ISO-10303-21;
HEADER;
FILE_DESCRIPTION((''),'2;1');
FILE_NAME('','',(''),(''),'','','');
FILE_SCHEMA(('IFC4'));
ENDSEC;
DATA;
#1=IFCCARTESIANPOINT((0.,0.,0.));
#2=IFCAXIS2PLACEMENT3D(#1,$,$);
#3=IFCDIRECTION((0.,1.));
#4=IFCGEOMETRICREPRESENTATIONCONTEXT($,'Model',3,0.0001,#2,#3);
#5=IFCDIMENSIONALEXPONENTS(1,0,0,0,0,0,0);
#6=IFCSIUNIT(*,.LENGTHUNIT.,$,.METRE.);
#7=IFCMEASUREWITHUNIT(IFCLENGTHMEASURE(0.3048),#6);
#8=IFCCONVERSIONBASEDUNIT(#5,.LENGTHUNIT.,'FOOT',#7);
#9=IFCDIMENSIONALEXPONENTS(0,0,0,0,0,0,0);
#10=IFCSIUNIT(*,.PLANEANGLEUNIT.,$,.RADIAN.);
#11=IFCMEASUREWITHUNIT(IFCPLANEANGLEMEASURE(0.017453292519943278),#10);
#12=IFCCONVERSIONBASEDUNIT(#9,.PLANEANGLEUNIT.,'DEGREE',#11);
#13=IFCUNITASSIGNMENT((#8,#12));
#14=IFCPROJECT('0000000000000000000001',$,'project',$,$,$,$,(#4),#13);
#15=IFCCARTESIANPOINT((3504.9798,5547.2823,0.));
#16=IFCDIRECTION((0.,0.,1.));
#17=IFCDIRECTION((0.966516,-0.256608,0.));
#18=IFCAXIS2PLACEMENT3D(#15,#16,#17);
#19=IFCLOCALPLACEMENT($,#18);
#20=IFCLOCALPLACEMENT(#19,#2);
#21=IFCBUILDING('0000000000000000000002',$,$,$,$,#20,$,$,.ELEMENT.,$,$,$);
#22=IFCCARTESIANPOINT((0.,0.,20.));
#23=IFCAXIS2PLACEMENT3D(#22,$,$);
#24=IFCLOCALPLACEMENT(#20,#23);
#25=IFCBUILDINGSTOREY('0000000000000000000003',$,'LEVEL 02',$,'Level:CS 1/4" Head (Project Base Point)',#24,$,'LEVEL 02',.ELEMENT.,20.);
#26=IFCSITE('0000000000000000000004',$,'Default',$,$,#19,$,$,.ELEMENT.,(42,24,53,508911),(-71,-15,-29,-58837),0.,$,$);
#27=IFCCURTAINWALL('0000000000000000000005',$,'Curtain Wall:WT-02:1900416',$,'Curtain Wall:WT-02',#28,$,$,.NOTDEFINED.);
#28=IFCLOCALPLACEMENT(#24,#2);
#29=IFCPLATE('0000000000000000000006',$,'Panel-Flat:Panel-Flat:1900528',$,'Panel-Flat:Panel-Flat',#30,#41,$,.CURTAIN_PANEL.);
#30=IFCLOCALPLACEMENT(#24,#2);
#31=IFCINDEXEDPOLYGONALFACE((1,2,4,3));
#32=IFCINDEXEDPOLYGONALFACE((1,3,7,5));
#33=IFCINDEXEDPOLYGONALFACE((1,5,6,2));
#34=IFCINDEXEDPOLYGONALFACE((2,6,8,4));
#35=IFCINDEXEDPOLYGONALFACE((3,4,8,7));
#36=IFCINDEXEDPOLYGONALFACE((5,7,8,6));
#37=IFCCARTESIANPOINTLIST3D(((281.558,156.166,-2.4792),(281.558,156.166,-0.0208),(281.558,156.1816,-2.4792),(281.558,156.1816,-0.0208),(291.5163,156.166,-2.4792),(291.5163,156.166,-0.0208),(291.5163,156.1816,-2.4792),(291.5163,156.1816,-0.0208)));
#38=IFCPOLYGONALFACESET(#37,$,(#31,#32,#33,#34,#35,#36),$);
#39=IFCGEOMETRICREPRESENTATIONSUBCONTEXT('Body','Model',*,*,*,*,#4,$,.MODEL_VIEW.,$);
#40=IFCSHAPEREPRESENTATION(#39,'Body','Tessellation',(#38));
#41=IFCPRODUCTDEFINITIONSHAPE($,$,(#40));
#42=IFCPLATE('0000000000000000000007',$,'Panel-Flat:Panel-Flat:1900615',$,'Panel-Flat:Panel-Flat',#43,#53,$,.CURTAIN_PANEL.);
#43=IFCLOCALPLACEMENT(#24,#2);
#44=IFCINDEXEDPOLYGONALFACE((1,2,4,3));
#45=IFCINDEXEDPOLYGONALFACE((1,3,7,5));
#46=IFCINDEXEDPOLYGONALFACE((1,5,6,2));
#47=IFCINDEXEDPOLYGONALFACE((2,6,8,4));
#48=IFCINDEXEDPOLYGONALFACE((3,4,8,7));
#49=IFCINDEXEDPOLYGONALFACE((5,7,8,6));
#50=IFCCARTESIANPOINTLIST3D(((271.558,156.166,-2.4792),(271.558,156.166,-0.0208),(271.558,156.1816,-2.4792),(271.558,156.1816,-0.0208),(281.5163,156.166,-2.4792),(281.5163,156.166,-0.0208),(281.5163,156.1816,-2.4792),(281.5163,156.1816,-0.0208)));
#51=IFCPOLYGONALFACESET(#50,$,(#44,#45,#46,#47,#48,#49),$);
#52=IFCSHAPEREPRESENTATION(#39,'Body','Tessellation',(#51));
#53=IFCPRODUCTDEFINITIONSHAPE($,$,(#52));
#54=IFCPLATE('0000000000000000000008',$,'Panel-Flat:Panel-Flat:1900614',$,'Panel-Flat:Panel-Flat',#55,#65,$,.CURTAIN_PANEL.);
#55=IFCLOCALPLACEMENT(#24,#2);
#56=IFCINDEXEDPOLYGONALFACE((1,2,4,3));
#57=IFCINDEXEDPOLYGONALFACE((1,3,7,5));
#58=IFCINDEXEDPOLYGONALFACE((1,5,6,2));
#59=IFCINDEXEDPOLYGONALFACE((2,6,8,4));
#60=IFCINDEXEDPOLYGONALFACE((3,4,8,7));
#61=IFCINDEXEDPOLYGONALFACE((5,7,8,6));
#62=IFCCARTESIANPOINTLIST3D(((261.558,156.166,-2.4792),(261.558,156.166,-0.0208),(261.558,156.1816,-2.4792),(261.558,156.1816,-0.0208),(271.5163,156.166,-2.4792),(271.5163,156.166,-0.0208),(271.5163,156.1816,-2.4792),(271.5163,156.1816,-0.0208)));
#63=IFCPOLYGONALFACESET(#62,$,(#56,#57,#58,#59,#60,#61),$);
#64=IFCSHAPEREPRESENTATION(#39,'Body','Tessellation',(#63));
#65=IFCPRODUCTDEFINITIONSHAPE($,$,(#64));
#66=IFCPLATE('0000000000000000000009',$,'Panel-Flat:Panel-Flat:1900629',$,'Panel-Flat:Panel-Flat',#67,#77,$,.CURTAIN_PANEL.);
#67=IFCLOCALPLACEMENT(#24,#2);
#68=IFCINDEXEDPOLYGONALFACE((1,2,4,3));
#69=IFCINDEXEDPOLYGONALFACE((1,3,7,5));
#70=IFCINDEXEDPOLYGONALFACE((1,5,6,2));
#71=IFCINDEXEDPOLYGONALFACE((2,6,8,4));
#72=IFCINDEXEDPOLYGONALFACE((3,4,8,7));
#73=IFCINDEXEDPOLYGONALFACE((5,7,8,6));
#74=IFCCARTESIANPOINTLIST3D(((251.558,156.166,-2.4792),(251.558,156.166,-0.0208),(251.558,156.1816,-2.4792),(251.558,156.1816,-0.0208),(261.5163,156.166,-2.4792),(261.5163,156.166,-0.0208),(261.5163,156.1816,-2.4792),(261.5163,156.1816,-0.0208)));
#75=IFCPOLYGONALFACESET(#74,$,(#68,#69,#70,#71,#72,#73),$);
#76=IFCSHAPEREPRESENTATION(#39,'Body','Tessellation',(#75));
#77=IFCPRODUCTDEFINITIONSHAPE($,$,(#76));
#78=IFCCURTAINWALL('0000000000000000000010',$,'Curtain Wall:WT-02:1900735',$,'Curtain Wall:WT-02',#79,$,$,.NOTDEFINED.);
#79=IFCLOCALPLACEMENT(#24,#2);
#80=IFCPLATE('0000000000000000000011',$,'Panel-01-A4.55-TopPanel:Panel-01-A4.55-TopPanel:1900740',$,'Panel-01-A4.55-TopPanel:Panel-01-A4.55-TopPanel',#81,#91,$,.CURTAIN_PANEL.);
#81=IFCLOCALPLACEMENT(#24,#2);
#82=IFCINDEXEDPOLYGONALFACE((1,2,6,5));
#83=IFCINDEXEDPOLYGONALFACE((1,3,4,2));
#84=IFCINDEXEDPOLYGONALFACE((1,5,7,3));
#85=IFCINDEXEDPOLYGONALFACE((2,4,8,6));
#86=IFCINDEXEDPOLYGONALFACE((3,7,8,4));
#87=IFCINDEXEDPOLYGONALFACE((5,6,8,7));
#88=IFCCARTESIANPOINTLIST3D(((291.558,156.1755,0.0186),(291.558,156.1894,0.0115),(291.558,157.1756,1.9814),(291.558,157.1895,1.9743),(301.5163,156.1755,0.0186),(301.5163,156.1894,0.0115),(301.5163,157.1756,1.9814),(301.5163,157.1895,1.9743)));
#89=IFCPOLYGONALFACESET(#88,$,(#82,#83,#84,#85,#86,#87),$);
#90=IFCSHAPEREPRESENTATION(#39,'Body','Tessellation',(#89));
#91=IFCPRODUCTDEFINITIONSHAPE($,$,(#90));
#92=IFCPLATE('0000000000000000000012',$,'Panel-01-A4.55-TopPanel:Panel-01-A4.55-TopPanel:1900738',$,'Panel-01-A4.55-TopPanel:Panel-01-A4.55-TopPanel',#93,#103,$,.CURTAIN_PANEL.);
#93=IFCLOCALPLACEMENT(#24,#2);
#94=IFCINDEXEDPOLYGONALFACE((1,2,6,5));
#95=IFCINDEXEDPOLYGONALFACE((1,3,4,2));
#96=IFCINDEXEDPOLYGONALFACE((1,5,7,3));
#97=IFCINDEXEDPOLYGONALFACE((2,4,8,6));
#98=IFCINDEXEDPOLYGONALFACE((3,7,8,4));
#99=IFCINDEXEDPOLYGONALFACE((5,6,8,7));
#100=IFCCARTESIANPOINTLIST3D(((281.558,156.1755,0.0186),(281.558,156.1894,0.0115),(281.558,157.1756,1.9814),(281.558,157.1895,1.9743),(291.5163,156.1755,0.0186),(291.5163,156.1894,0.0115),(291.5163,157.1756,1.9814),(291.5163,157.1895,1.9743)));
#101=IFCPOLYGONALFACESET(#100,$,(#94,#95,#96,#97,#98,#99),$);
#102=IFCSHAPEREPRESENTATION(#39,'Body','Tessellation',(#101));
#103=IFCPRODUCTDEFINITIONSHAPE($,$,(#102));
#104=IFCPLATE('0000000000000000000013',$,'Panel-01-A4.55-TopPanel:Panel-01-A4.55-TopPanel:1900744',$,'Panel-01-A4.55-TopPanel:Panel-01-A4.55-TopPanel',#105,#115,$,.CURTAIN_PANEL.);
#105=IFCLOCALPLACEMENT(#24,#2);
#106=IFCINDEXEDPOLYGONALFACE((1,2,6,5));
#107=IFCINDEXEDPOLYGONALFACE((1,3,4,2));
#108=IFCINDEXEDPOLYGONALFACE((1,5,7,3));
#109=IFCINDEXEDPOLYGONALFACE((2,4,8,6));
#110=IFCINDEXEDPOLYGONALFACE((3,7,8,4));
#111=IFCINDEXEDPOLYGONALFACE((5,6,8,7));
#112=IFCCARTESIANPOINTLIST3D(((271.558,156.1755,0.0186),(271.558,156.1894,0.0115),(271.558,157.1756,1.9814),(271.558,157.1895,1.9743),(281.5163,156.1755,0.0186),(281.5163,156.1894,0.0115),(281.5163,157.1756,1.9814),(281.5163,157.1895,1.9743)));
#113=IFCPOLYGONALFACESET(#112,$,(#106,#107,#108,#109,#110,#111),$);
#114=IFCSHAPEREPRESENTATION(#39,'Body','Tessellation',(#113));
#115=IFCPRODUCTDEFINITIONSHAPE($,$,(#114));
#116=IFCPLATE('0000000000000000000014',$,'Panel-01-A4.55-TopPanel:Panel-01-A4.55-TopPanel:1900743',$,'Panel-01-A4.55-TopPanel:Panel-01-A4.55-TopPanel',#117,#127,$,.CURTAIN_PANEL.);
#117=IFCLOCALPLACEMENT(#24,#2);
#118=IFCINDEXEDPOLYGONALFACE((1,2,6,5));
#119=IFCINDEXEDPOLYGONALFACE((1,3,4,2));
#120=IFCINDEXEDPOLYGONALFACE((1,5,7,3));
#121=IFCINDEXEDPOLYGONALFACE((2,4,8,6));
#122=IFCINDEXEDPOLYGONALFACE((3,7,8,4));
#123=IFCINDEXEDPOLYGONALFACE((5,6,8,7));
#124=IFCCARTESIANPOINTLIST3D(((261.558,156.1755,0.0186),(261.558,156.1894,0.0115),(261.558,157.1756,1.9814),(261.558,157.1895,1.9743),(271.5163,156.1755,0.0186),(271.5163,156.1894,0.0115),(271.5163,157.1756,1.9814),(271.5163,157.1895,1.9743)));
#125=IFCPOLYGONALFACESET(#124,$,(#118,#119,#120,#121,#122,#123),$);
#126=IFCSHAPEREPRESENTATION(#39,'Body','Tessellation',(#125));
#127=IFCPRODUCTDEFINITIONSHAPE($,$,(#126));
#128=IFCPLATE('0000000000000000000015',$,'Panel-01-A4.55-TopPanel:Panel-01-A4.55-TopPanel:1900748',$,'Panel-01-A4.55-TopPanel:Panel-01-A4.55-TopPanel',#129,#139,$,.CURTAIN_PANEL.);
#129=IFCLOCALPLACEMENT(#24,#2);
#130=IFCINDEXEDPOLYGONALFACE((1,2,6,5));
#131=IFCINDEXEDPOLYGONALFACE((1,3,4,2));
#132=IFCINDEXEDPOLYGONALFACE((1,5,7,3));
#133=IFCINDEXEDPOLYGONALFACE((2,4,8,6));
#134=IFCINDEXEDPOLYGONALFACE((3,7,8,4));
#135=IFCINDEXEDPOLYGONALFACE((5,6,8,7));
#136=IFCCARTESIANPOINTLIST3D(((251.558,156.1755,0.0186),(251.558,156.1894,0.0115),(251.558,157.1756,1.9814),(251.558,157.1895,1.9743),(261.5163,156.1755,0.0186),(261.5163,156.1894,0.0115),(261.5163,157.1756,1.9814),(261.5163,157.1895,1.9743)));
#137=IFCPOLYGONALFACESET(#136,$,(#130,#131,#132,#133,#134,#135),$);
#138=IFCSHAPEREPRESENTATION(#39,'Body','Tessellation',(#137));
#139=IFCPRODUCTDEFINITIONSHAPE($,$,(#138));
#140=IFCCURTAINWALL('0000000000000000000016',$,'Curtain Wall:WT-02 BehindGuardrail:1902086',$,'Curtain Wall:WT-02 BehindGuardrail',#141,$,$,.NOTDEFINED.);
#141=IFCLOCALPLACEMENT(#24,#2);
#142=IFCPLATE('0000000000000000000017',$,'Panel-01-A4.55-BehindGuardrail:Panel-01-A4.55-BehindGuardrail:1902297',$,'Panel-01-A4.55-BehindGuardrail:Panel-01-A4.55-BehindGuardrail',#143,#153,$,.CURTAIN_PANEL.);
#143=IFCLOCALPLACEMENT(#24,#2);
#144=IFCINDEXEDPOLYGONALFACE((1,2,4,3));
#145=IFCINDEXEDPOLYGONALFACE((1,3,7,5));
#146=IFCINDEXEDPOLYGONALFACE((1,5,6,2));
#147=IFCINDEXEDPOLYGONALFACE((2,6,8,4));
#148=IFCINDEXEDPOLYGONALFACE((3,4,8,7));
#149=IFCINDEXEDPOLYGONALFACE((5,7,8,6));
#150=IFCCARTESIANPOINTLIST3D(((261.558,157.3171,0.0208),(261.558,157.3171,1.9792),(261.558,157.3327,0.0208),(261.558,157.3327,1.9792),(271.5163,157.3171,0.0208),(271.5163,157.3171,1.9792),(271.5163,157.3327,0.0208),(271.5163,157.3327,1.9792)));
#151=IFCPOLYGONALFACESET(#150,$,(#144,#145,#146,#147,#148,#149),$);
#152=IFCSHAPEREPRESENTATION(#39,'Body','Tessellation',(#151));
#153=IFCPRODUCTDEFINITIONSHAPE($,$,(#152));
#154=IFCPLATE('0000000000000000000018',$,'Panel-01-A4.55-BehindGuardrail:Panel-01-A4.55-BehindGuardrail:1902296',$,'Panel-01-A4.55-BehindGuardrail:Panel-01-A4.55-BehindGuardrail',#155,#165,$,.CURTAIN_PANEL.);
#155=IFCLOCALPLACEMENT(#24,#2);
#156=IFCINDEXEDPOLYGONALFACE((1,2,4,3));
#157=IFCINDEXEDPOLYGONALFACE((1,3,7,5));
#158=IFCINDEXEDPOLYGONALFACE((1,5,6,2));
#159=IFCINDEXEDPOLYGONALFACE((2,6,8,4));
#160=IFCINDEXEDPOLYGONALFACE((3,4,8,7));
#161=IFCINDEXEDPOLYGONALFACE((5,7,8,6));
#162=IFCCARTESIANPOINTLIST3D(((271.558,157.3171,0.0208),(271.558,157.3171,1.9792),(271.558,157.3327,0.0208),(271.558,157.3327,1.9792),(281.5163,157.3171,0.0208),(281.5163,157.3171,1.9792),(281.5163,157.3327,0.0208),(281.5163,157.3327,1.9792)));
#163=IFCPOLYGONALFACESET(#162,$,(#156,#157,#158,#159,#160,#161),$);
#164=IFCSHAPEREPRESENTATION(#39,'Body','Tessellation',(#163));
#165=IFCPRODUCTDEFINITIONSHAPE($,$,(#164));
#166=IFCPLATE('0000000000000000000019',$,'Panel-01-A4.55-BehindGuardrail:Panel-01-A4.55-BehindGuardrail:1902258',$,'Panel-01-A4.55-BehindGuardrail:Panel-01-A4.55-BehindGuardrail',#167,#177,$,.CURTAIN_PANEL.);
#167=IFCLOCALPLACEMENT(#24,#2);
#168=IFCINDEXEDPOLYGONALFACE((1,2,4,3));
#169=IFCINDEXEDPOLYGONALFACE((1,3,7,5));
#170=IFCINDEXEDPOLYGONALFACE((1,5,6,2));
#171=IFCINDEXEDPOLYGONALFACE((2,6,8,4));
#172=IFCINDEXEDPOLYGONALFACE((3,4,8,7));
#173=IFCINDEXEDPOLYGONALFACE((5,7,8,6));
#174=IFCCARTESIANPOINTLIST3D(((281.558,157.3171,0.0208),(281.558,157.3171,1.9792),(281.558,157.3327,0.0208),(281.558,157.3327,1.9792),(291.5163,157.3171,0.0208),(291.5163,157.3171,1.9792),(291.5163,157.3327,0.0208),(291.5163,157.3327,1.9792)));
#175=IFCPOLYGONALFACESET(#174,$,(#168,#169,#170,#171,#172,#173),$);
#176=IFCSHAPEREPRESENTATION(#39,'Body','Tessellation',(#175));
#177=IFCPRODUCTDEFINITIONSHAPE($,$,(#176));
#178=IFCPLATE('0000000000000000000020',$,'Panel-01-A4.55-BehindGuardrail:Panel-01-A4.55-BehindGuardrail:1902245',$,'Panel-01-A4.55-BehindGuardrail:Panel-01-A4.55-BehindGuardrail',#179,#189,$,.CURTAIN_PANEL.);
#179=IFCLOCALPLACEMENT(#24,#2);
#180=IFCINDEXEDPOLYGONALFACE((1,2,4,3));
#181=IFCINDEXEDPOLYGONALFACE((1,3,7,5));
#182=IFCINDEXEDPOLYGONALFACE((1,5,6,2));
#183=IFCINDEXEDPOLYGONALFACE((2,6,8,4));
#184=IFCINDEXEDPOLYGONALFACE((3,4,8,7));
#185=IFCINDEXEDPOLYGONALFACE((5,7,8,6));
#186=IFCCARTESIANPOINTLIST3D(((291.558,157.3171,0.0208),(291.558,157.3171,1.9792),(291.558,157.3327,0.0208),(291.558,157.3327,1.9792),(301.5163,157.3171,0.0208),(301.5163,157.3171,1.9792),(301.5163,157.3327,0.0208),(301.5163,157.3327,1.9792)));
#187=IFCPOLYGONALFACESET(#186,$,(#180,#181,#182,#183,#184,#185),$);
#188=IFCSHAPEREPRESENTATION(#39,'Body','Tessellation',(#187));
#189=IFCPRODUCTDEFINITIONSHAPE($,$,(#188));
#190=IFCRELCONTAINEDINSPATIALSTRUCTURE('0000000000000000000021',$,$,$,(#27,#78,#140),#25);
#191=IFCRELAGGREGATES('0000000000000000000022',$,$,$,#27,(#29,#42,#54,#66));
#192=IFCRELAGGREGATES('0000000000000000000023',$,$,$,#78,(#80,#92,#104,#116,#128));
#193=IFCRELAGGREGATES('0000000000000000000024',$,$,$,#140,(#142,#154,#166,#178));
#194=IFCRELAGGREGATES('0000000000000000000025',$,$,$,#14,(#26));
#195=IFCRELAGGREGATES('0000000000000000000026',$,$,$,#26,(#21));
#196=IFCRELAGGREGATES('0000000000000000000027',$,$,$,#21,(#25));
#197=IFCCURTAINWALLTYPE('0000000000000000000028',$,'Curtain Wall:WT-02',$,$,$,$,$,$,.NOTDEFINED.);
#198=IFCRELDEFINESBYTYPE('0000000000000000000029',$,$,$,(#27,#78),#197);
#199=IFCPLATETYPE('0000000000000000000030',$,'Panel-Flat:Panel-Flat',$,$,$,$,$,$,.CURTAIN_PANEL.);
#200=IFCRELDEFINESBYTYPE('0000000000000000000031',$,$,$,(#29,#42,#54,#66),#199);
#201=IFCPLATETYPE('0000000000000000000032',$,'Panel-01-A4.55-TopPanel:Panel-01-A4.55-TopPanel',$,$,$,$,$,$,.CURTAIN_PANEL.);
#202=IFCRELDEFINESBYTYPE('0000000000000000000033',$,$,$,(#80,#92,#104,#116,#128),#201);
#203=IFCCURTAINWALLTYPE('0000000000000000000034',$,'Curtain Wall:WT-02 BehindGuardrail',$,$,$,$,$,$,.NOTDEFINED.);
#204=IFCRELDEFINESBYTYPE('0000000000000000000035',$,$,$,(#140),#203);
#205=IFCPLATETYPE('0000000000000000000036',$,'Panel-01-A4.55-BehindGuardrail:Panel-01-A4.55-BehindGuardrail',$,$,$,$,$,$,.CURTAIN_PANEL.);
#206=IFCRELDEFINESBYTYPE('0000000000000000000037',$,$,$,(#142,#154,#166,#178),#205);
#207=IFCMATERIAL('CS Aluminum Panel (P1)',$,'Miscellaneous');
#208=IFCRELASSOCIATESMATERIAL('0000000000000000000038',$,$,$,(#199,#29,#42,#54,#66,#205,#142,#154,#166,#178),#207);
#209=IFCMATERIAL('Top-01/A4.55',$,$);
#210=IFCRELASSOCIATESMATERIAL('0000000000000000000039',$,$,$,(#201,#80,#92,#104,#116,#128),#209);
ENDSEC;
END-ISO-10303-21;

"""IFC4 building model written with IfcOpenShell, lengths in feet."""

from ifc_helpers import new_model, entity, si_unit, converted_unit, direction, frame, origin, place, context, subcontext, project, spatial, indexed_curve, outline, extrude, source, transform, mapped, material, type_object, type_shapes, element, aggregate, save


model = new_model("IFC4")

# Units and contexts
model_context = context("Model", 3, precision=0.0001, world=origin(), true_north=direction((0.0, 1.0)))
body_context = subcontext(model_context, "Body", "Model", "MODEL_VIEW")
ifc_project = project(units=[converted_unit("LENGTHUNIT", "FOOT", entity("IfcLengthMeasure", 0.3048), si_unit("LENGTHUNIT", "METRE"), dimensions=[1, 0, 0, 0, 0, 0, 0]), converted_unit("PLANEANGLEUNIT", "DEGREE", entity("IfcPlaneAngleMeasure", 0.017453292519943278), si_unit("PLANEANGLEUNIT", "RADIAN"), dimensions=[0, 0, 0, 0, 0, 0, 0])], contexts=[model_context])

# Site, building, storey
site_placement = place(None, frame((3504.9798, 5547.2823, 0.0), z_axis=(0.0, 0.0, 1.0), x_axis=(0.966516, -0.256608, 0.0)))
site = spatial("IfcSite", under=ifc_project, at=site_placement, Name="Default", CompositionType="ELEMENT", RefLatitude=(42, 24, 53, 508911), RefLongitude=(-71, -15, -29, -58837), RefElevation=0.0)
building_placement = place(site_placement, origin())
building = spatial("IfcBuilding", under=site, at=building_placement, CompositionType="ELEMENT")
storey_placement = place(building_placement, frame((0.0, 0.0, 20.0)))
storey = spatial("IfcBuildingStorey", under=building, at=storey_placement, Name="LEVEL 02", ObjectType="Level:CS 1/4\" Head (Project Base Point)", LongName="LEVEL 02", CompositionType="ELEMENT", Elevation=20.0)

# Curtain walls, plates
curtain_wall_type_1 = type_object("IfcCurtainWallType", Name="Curtain Wall:WT-02", PredefinedType="NOTDEFINED")
ifc_material_1 = material(Name="CS Aluminum Panel (P1)", Category="Miscellaneous")
curtain_wall_1_placement = place(storey_placement, frame((0.0, 0.0, -20.0)))
curtain_wall_1 = element("IfcCurtainWall", 1, at=curtain_wall_1_placement, inside=storey, type_object=curtain_wall_type_1, Name="Curtain Wall:WT-02:1900416", ObjectType="Curtain Wall:WT-02", PredefinedType="NOTDEFINED")
plate_type_1 = type_object("IfcPlateType", Name="Panel-Flat:Panel-Flat", PredefinedType="CURTAIN_PANEL", material=ifc_material_1)
shared_shape_1 = source(origin(), body_context, "Body", "SweptSolid", [
    extrude(outline(indexed_curve([(-0.0078, -4.9792), (0.0078, -4.9792), (0.0078, 4.9792), (-0.0078, 4.9792), (-0.0078, -4.9792)], self_intersect=False)), frame((4.9792, 0.0078, 0.0), z_axis=(0.0, 0.0, 1.0), x_axis=(0.0, -1.0, 0.0)), (0.0, 0.0, 1.0), 2.4583),
])
type_shapes(plate_type_1, [shared_shape_1])
plate_1_placement = place(curtain_wall_1_placement, frame((291.5163, 156.1816, 17.5208), z_axis=(0.0, 0.0, 1.0), x_axis=(-1.0, 0.0, 0.0)))
plate_1 = element("IfcPlate", 2, at=plate_1_placement, type_object=plate_type_1, material=ifc_material_1, Name="Panel-Flat:Panel-Flat:1900528", ObjectType="Panel-Flat:Panel-Flat", PredefinedType="CURTAIN_PANEL", context=body_context, shape_type="MappedRepresentation", body=[
    mapped(shared_shape_1, transform((0.0, 0.0, 0.0), scale=1.0)),
])
plate_2_placement = place(curtain_wall_1_placement, frame((281.5163, 156.1816, 17.5208), z_axis=(0.0, 0.0, 1.0), x_axis=(-1.0, 0.0, 0.0)))
plate_2 = element("IfcPlate", 3, at=plate_2_placement, type_object=plate_type_1, material=ifc_material_1, Name="Panel-Flat:Panel-Flat:1900615", ObjectType="Panel-Flat:Panel-Flat", PredefinedType="CURTAIN_PANEL", context=body_context, shape_type="MappedRepresentation", body=[
    mapped(shared_shape_1, transform((0.0, 0.0, 0.0), scale=1.0)),
])
plate_3_placement = place(curtain_wall_1_placement, frame((271.5163, 156.1816, 17.5208), z_axis=(0.0, 0.0, 1.0), x_axis=(-1.0, 0.0, 0.0)))
plate_3 = element("IfcPlate", 4, at=plate_3_placement, type_object=plate_type_1, material=ifc_material_1, Name="Panel-Flat:Panel-Flat:1900614", ObjectType="Panel-Flat:Panel-Flat", PredefinedType="CURTAIN_PANEL", context=body_context, shape_type="MappedRepresentation", body=[
    mapped(shared_shape_1, transform((0.0, 0.0, 0.0), scale=1.0)),
])
plate_4_placement = place(curtain_wall_1_placement, frame((261.5163, 156.1816, 17.5208), z_axis=(0.0, 0.0, 1.0), x_axis=(-1.0, 0.0, 0.0)))
plate_4 = element("IfcPlate", 5, at=plate_4_placement, type_object=plate_type_1, material=ifc_material_1, Name="Panel-Flat:Panel-Flat:1900629", ObjectType="Panel-Flat:Panel-Flat", PredefinedType="CURTAIN_PANEL", context=body_context, shape_type="MappedRepresentation", body=[
    mapped(shared_shape_1, transform((0.0, 0.0, 0.0), scale=1.0)),
])
aggregate(curtain_wall_1, [plate_1, plate_2, plate_3, plate_4])
curtain_wall_2_placement = place(storey_placement, frame((0.0, 0.0, -20.0)))
curtain_wall_2 = element("IfcCurtainWall", 6, at=curtain_wall_2_placement, inside=storey, type_object=curtain_wall_type_1, Name="Curtain Wall:WT-02:1900735", ObjectType="Curtain Wall:WT-02", PredefinedType="NOTDEFINED")
ifc_material_2 = material(Name="Top-01/A4.55")
plate_type_2 = type_object("IfcPlateType", Name="Panel-01-A4.55-TopPanel:Panel-01-A4.55-TopPanel", PredefinedType="CURTAIN_PANEL", material=ifc_material_2)
shared_shape_2 = source(origin(), body_context, "Body", "SweptSolid", [
    extrude(outline(indexed_curve([(-0.0078, -4.9792), (0.0078, -4.9792), (0.0078, 4.9792), (-0.0078, 4.9792), (-0.0078, -4.9792)], self_intersect=False)), frame((4.9792, 0.0078, 0.0), z_axis=(0.0, 0.0, 1.0), x_axis=(0.0, -1.0, 0.0)), (0.0, 0.0, 1.0), 2.203),
])
type_shapes(plate_type_2, [shared_shape_2])
plate_5_placement = place(curtain_wall_2_placement, frame((301.5163, 156.1894, 20.0115), z_axis=(0.0, 0.45399, 0.891007), x_axis=(-1.0, 0.0, 0.0)))
plate_5 = element("IfcPlate", 7, at=plate_5_placement, type_object=plate_type_2, material=ifc_material_2, Name="Panel-01-A4.55-TopPanel:Panel-01-A4.55-TopPanel:1900740", ObjectType="Panel-01-A4.55-TopPanel:Panel-01-A4.55-TopPanel", PredefinedType="CURTAIN_PANEL", context=body_context, shape_type="MappedRepresentation", body=[
    mapped(shared_shape_2, transform((0.0, 0.0, 0.0), scale=1.0)),
])
plate_6_placement = place(curtain_wall_2_placement, frame((291.5163, 156.1894, 20.0115), z_axis=(0.0, 0.45399, 0.891007), x_axis=(-1.0, 0.0, 0.0)))
plate_6 = element("IfcPlate", 8, at=plate_6_placement, type_object=plate_type_2, material=ifc_material_2, Name="Panel-01-A4.55-TopPanel:Panel-01-A4.55-TopPanel:1900738", ObjectType="Panel-01-A4.55-TopPanel:Panel-01-A4.55-TopPanel", PredefinedType="CURTAIN_PANEL", context=body_context, shape_type="MappedRepresentation", body=[
    mapped(shared_shape_2, transform((0.0, 0.0, 0.0), scale=1.0)),
])
plate_7_placement = place(curtain_wall_2_placement, frame((281.5163, 156.1894, 20.0115), z_axis=(0.0, 0.45399, 0.891007), x_axis=(-1.0, 0.0, 0.0)))
plate_7 = element("IfcPlate", 9, at=plate_7_placement, type_object=plate_type_2, material=ifc_material_2, Name="Panel-01-A4.55-TopPanel:Panel-01-A4.55-TopPanel:1900744", ObjectType="Panel-01-A4.55-TopPanel:Panel-01-A4.55-TopPanel", PredefinedType="CURTAIN_PANEL", context=body_context, shape_type="MappedRepresentation", body=[
    mapped(shared_shape_2, transform((0.0, 0.0, 0.0), scale=1.0)),
])
plate_8_placement = place(curtain_wall_2_placement, frame((271.5163, 156.1894, 20.0115), z_axis=(0.0, 0.45399, 0.891007), x_axis=(-1.0, 0.0, 0.0)))
plate_8 = element("IfcPlate", 10, at=plate_8_placement, type_object=plate_type_2, material=ifc_material_2, Name="Panel-01-A4.55-TopPanel:Panel-01-A4.55-TopPanel:1900743", ObjectType="Panel-01-A4.55-TopPanel:Panel-01-A4.55-TopPanel", PredefinedType="CURTAIN_PANEL", context=body_context, shape_type="MappedRepresentation", body=[
    mapped(shared_shape_2, transform((0.0, 0.0, 0.0), scale=1.0)),
])
plate_9_placement = place(curtain_wall_2_placement, frame((261.5163, 156.1894, 20.0115), z_axis=(0.0, 0.45399, 0.891007), x_axis=(-1.0, 0.0, 0.0)))
plate_9 = element("IfcPlate", 11, at=plate_9_placement, type_object=plate_type_2, material=ifc_material_2, Name="Panel-01-A4.55-TopPanel:Panel-01-A4.55-TopPanel:1900748", ObjectType="Panel-01-A4.55-TopPanel:Panel-01-A4.55-TopPanel", PredefinedType="CURTAIN_PANEL", context=body_context, shape_type="MappedRepresentation", body=[
    mapped(shared_shape_2, transform((0.0, 0.0, 0.0), scale=1.0)),
])
aggregate(curtain_wall_2, [plate_5, plate_6, plate_7, plate_8, plate_9])
curtain_wall_type_2 = type_object("IfcCurtainWallType", Name="Curtain Wall:WT-02 BehindGuardrail", PredefinedType="NOTDEFINED")
curtain_wall_3_placement = place(storey_placement, frame((0.0, 0.0, -20.0)))
curtain_wall_3 = element("IfcCurtainWall", 12, at=curtain_wall_3_placement, inside=storey, type_object=curtain_wall_type_2, Name="Curtain Wall:WT-02 BehindGuardrail:1902086", ObjectType="Curtain Wall:WT-02 BehindGuardrail", PredefinedType="NOTDEFINED")
plate_type_3 = type_object("IfcPlateType", Name="Panel-01-A4.55-BehindGuardrail:Panel-01-A4.55-BehindGuardrail", PredefinedType="CURTAIN_PANEL", material=ifc_material_1)
shared_shape_3 = source(origin(), body_context, "Body", "SweptSolid", [
    extrude(outline(indexed_curve([(-0.0078, -4.9792), (0.0078, -4.9792), (0.0078, 4.9792), (-0.0078, 4.9792), (-0.0078, -4.9792)], self_intersect=False)), frame((4.9792, 0.0078, 0.0), z_axis=(0.0, 0.0, 1.0), x_axis=(0.0, -1.0, 0.0)), (0.0, 0.0, 1.0), 1.9583),
])
type_shapes(plate_type_3, [shared_shape_3])
plate_10_placement = place(curtain_wall_3_placement, frame((261.558, 157.3171, 20.0208)))
plate_10 = element("IfcPlate", 13, at=plate_10_placement, type_object=plate_type_3, material=ifc_material_1, Name="Panel-01-A4.55-BehindGuardrail:Panel-01-A4.55-BehindGuardrail:1902297", ObjectType="Panel-01-A4.55-BehindGuardrail:Panel-01-A4.55-BehindGuardrail", PredefinedType="CURTAIN_PANEL", context=body_context, shape_type="MappedRepresentation", body=[
    mapped(shared_shape_3, transform((0.0, 0.0, 0.0), scale=1.0)),
])
plate_11_placement = place(curtain_wall_3_placement, frame((271.558, 157.3171, 20.0208)))
plate_11 = element("IfcPlate", 14, at=plate_11_placement, type_object=plate_type_3, material=ifc_material_1, Name="Panel-01-A4.55-BehindGuardrail:Panel-01-A4.55-BehindGuardrail:1902296", ObjectType="Panel-01-A4.55-BehindGuardrail:Panel-01-A4.55-BehindGuardrail", PredefinedType="CURTAIN_PANEL", context=body_context, shape_type="MappedRepresentation", body=[
    mapped(shared_shape_3, transform((0.0, 0.0, 0.0), scale=1.0)),
])
plate_12_placement = place(curtain_wall_3_placement, frame((281.558, 157.3171, 20.0208)))
plate_12 = element("IfcPlate", 15, at=plate_12_placement, type_object=plate_type_3, material=ifc_material_1, Name="Panel-01-A4.55-BehindGuardrail:Panel-01-A4.55-BehindGuardrail:1902258", ObjectType="Panel-01-A4.55-BehindGuardrail:Panel-01-A4.55-BehindGuardrail", PredefinedType="CURTAIN_PANEL", context=body_context, shape_type="MappedRepresentation", body=[
    mapped(shared_shape_3, transform((0.0, 0.0, 0.0), scale=1.0)),
])
plate_13_placement = place(curtain_wall_3_placement, frame((291.558, 157.3171, 20.0208)))
plate_13 = element("IfcPlate", 16, at=plate_13_placement, type_object=plate_type_3, material=ifc_material_1, Name="Panel-01-A4.55-BehindGuardrail:Panel-01-A4.55-BehindGuardrail:1902245", ObjectType="Panel-01-A4.55-BehindGuardrail:Panel-01-A4.55-BehindGuardrail", PredefinedType="CURTAIN_PANEL", context=body_context, shape_type="MappedRepresentation", body=[
    mapped(shared_shape_3, transform((0.0, 0.0, 0.0), scale=1.0)),
])
aggregate(curtain_wall_3, [plate_10, plate_11, plate_12, plate_13])

save(model, "model.ifc")
